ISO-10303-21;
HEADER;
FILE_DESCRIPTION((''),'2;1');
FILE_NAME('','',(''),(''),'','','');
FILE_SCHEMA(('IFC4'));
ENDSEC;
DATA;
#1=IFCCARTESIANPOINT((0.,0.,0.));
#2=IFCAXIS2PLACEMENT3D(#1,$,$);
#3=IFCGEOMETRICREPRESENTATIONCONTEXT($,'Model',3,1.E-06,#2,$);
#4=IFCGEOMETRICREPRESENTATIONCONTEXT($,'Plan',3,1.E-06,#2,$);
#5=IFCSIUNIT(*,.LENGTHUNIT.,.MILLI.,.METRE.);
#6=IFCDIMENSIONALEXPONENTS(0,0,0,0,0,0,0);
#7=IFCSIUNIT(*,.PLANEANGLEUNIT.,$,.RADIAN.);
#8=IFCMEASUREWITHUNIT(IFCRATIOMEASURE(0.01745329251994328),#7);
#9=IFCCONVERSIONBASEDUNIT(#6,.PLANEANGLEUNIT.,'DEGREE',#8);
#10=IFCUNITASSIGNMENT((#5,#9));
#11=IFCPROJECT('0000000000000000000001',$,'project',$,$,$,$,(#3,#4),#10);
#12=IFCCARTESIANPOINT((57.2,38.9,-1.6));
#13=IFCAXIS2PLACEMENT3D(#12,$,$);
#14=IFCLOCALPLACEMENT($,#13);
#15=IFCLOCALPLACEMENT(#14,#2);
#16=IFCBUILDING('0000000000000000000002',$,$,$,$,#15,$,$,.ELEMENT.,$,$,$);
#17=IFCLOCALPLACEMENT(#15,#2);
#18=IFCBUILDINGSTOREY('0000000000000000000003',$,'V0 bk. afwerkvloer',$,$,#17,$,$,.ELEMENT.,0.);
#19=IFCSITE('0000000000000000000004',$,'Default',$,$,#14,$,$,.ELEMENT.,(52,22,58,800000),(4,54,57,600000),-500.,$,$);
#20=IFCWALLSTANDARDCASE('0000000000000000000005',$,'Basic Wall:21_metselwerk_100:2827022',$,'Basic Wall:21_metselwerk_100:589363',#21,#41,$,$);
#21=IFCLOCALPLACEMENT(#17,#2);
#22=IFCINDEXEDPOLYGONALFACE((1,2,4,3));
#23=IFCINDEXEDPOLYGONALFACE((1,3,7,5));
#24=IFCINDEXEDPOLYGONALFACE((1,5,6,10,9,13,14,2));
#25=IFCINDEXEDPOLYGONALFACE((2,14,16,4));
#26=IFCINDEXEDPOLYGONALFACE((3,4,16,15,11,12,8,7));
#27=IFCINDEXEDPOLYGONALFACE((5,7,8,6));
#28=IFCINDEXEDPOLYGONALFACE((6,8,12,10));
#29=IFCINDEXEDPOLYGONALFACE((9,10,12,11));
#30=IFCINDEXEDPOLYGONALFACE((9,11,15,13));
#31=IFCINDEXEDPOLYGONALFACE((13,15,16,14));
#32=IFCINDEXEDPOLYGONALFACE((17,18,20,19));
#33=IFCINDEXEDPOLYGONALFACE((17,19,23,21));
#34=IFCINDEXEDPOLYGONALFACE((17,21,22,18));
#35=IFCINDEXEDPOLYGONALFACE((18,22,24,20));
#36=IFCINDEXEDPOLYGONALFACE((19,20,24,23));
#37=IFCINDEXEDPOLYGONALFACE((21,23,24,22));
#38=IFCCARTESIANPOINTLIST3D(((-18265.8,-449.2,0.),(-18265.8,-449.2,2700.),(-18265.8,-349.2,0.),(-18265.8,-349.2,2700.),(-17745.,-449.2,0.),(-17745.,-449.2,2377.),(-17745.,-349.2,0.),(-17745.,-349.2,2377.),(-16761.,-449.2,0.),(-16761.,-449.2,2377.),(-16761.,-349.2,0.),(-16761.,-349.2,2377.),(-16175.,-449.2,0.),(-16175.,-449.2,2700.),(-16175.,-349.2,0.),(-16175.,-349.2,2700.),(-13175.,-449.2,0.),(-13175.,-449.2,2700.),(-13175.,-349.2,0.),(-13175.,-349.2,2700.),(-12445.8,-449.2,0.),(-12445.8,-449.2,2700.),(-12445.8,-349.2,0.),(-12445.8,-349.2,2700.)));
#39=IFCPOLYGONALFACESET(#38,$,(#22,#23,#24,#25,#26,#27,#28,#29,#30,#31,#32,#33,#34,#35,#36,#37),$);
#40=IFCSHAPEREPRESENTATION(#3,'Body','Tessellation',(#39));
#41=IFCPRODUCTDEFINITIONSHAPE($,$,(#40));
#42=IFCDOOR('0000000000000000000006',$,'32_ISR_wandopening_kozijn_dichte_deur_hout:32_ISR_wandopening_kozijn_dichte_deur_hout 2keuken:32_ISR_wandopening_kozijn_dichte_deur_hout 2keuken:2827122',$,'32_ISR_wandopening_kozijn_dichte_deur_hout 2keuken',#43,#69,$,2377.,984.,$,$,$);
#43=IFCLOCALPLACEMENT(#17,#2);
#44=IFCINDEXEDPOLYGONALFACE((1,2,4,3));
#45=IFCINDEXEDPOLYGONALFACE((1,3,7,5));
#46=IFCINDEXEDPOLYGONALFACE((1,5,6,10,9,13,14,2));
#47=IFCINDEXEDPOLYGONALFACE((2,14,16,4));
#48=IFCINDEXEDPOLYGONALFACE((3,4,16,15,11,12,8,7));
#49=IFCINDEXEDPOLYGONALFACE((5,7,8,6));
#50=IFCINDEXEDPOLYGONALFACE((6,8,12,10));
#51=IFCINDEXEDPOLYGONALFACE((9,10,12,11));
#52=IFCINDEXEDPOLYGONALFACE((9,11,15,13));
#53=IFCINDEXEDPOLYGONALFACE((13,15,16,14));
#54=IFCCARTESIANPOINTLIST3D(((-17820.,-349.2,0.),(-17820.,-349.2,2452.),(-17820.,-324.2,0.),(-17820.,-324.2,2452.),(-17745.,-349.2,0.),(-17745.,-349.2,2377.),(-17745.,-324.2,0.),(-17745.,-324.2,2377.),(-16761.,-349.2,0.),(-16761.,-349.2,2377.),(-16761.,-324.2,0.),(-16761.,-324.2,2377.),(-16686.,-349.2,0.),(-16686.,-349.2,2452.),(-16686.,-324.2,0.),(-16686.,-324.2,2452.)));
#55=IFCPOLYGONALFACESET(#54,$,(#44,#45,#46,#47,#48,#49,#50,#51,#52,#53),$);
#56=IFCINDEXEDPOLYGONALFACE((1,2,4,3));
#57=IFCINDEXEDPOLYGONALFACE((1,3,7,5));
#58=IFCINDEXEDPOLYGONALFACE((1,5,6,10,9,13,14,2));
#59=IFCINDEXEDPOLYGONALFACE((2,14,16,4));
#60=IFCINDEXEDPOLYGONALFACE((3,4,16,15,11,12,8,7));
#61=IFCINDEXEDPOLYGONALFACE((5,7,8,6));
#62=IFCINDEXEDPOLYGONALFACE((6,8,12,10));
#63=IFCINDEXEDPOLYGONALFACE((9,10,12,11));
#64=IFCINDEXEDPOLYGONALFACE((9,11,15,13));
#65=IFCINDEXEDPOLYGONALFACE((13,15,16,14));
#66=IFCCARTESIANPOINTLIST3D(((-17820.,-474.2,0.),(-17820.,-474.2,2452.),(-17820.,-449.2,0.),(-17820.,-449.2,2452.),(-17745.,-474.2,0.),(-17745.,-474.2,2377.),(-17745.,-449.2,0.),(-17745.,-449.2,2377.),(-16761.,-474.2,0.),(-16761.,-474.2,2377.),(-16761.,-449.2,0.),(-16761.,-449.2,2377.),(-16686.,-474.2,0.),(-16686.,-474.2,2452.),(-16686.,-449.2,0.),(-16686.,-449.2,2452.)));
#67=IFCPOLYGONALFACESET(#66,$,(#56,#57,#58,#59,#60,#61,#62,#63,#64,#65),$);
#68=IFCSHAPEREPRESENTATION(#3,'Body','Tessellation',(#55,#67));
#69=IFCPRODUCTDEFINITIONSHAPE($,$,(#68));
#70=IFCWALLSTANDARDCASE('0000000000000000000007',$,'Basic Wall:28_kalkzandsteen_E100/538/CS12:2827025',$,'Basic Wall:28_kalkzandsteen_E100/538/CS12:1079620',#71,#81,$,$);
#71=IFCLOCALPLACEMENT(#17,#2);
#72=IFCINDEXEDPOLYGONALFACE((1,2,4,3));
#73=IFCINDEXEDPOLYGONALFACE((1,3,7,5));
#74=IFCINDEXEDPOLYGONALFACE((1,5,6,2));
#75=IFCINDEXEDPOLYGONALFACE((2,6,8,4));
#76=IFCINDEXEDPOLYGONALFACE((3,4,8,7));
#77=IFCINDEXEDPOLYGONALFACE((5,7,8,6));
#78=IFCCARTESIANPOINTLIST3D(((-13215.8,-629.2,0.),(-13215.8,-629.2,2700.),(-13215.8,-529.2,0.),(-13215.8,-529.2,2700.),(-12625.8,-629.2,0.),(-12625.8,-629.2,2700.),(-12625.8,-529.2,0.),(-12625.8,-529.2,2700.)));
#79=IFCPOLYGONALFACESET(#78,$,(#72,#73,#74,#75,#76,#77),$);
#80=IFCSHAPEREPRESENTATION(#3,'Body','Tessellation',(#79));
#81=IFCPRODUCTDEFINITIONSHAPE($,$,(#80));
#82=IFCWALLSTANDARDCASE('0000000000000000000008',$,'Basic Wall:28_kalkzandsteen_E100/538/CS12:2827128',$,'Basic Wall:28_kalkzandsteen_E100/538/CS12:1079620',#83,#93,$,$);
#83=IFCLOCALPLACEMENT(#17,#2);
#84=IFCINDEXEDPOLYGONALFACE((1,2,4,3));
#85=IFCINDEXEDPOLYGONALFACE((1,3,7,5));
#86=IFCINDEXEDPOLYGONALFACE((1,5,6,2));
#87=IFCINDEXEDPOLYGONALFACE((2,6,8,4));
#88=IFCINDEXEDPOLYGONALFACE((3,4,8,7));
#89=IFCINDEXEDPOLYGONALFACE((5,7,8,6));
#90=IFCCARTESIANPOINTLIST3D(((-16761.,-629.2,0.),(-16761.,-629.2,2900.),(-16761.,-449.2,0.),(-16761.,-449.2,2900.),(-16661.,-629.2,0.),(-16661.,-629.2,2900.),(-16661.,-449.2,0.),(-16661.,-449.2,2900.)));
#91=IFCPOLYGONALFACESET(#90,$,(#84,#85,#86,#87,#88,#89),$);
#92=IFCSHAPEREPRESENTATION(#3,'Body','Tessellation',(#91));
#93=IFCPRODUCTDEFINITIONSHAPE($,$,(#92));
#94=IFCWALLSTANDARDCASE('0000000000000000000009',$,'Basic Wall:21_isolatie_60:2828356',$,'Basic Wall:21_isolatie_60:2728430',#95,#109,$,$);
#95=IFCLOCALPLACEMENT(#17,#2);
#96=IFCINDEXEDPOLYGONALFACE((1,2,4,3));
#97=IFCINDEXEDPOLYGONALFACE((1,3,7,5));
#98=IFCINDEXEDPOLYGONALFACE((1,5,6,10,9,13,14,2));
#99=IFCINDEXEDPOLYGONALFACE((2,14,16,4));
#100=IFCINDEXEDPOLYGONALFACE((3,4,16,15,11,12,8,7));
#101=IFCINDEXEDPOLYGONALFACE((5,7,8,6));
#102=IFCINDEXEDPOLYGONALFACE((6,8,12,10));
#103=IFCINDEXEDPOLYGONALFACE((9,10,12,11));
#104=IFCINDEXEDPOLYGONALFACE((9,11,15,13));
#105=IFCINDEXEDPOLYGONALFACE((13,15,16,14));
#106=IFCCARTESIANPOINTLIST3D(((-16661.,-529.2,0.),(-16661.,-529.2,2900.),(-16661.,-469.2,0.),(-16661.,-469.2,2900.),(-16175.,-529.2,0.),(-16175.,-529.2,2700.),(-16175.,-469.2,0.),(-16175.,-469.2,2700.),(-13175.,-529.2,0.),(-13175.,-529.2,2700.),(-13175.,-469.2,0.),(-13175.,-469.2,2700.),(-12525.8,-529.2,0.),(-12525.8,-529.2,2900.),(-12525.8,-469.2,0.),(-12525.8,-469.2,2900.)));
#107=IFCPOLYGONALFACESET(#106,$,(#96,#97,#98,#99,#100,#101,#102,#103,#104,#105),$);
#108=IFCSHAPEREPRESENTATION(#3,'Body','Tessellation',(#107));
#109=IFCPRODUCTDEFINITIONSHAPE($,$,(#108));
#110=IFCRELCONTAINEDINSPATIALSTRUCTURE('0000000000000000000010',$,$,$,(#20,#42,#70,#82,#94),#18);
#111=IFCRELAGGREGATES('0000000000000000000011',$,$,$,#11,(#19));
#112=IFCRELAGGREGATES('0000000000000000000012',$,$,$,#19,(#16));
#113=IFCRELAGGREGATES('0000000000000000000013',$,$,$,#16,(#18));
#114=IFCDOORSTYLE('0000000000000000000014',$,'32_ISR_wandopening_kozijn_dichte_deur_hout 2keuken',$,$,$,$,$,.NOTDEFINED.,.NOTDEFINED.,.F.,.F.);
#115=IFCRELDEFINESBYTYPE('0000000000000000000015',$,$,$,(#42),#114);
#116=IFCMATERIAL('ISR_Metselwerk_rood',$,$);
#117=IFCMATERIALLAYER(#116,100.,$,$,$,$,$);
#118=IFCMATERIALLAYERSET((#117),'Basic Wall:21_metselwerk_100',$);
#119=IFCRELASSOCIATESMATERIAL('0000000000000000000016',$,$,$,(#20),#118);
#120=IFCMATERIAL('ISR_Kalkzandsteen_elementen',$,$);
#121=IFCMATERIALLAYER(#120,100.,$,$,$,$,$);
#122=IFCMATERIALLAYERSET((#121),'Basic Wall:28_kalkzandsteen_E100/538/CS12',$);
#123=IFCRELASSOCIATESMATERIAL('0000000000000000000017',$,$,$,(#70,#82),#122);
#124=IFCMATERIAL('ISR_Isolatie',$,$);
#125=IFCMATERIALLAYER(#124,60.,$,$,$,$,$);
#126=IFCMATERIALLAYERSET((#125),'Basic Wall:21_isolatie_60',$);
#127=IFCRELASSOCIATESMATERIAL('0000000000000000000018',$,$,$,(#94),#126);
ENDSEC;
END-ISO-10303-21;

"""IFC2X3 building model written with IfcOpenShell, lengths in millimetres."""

from ifc_helpers import new_model, entity, si_unit, converted_unit, frame, frame_2d, origin, origin_2d_with_axis, place, context, project, spatial, polyline, rectangle, outline, extrude, source, transform, mapped, material, layer, layer_set, layer_usage, type_object, type_shapes, element, fill, save


model = new_model("IFC2X3")

# Units and contexts
model_context = context("Model", 3, precision=1e-06, world=origin())
plan_context = context("Plan", 3, precision=1e-06, world=origin())
ifc_project = project(units=[si_unit("LENGTHUNIT", "METRE", prefix="MILLI"), converted_unit("PLANEANGLEUNIT", "DEGREE", entity("IfcRatioMeasure", 0.01745329251994328), si_unit("PLANEANGLEUNIT", "RADIAN"), dimensions=[0, 0, 0, 0, 0, 0, 0])], contexts=[model_context, plan_context])

# Site, building, storey
site_placement = place(None, frame((57.2, 38.9, -1.6)))
site = spatial("IfcSite", under=ifc_project, at=site_placement, Name="Default", CompositionType="ELEMENT", RefLatitude=(52, 22, 58, 800000), RefLongitude=(4, 54, 57, 600000), RefElevation=-500.0)
building_placement = place(site_placement, origin())
building = spatial("IfcBuilding", under=site, at=building_placement, CompositionType="ELEMENT")
storey_placement = place(building_placement, origin())
storey = spatial("IfcBuildingStorey", under=building, at=storey_placement, Name="V0 bk. afwerkvloer", CompositionType="ELEMENT", Elevation=0.0)

# Shared definitions
ifc_material_1 = material(Name="ISR_Kalkzandsteen_elementen")
ifc_layer_1 = layer(ifc_material_1, 100.0)
ifc_layer_set_1 = layer_set([ifc_layer_1], Name="Basic Wall:28_kalkzandsteen_E100/538/CS12")

# Wall, openings, door
ifc_material_2 = material(Name="ISR_Metselwerk_rood")
ifc_layer_2 = layer(ifc_material_2, 100.0)
ifc_layer_set_2 = layer_set([ifc_layer_2], Name="Basic Wall:21_metselwerk_100")
ifc_layer_usage_1 = layer_usage(ifc_layer_set_2, "AXIS2", "NEGATIVE", 50.0)
wall_1_placement = place(storey_placement, frame((-18265.8, -399.2, 0.0)))
wall_1 = element("IfcWallStandardCase", 1, at=wall_1_placement, inside=storey, material=ifc_layer_usage_1, Name="Basic Wall:21_metselwerk_100:2827022", ObjectType="Basic Wall:21_metselwerk_100:589363", context=model_context, shape_type="SweptSolid", body=[
    extrude(rectangle(XDim=5820.0, YDim=100.0, at=frame_2d((2910.0, 0.0), x_axis=(-1.0, 0.0))), origin(), (0.0, 0.0, 1.0), 2700.0),
])
opening_1_placement = place(wall_1_placement, origin())
element("IfcOpeningElement", 2, at=opening_1_placement, cuts=wall_1, ObjectType="Opening", context=model_context, shape_type="SweptSolid", body=[
    extrude(rectangle(XDim=2700.0, YDim=3000.0, at=origin_2d_with_axis()), frame((3590.8, -202.4, 1350.0), z_axis=(0.0, 1.0, 0.0), x_axis=(0.0, 0.0, 1.0)), (0.0, 0.0, 1.0), 404.8),
])
opening_2_placement = place(wall_1_placement, frame((520.8, -50.0, 0.0)))
opening_2 = element("IfcOpeningElement", 3, at=opening_2_placement, cuts=wall_1, ObjectType="Opening", context=model_context, shape_type="SweptSolid", body=[
    extrude(rectangle(XDim=2377.0, YDim=984.0, at=frame_2d((1188.5, 492.0), x_axis=(1.0, 0.0))), frame((0.0, 0.0, 0.0), z_axis=(0.0, 1.0, 0.0), x_axis=(0.0, 0.0, 1.0)), (0.0, 0.0, 1.0), 100.0),
])
door_style_1 = type_object("IfcDoorStyle", Name="32_ISR_wandopening_kozijn_dichte_deur_hout 2keuken", ConstructionType="NOTDEFINED", OperationType="NOTDEFINED", ParameterTakesPrecedence=False, Sizeable=False)
shared_shape_1 = source(origin(), model_context, "Body", "SweptSolid", [
    extrude(outline(polyline([(-1169.7, 492.0), (1207.2, 492.0), (1207.2, 567.0), (-1244.7, 567.0), (-1244.7, -567.0), (1207.2, -567.0), (1207.2, -492.0), (-1169.7, -492.0), (-1169.7, 492.0)])), frame((1202.0, 125.0, 1207.2), z_axis=(0.0, -1.0, 0.0), x_axis=(0.0, 0.0, -1.0)), (0.0, 0.0, 1.0), 25.0),
    extrude(outline(polyline([(-567.0, -1244.7), (567.0, -1244.7), (567.0, 1207.2), (492.0, 1207.2), (492.0, -1169.7), (-492.0, -1169.7), (-492.0, 1207.2), (-567.0, 1207.2), (-567.0, -1244.7)])), frame((1202.0, 0.0, 1207.2), z_axis=(0.0, -1.0, 0.0), x_axis=(-1.0, 0.0, 0.0)), (0.0, 0.0, 1.0), 25.0),
])
type_shapes(door_style_1, [shared_shape_1])
door_1_placement = place(opening_2_placement, frame((-710.0, 0.0, 0.0)))
door_1 = element("IfcDoor", 4, at=door_1_placement, inside=storey, type_object=door_style_1, Name="32_ISR_wandopening_kozijn_dichte_deur_hout:32_ISR_wandopening_kozijn_dichte_deur_hout 2keuken:32_ISR_wandopening_kozijn_dichte_deur_hout 2keuken:2827122", ObjectType="32_ISR_wandopening_kozijn_dichte_deur_hout 2keuken", OverallHeight=2377.0, OverallWidth=984.0, context=model_context, shape_type="MappedRepresentation", body=[
    mapped(shared_shape_1, transform((0.0, 0.0, 0.0), scale=1.0)),
])
fill(opening_2, door_1)

# Wall
ifc_layer_usage_2 = layer_usage(ifc_layer_set_1, "AXIS2", "POSITIVE", -50.0)
wall_2_placement = place(storey_placement, frame((-13215.8, -579.2, 0.0)))
element("IfcWallStandardCase", 5, at=wall_2_placement, inside=storey, material=ifc_layer_usage_2, Name="Basic Wall:28_kalkzandsteen_E100/538/CS12:2827025", ObjectType="Basic Wall:28_kalkzandsteen_E100/538/CS12:1079620", context=model_context, shape_type="SweptSolid", body=[
    extrude(rectangle(XDim=590.0, YDim=100.0, at=frame_2d((295.0, 0.0), x_axis=(-1.0, 0.0))), origin(), (0.0, 0.0, 1.0), 2700.0),
])

# Wall
ifc_layer_usage_3 = layer_usage(ifc_layer_set_1, "AXIS2", "NEGATIVE", 50.0)
wall_3_placement = place(storey_placement, frame((-16711.0, -629.2, 0.0), z_axis=(0.0, 0.0, 1.0), x_axis=(0.0, 1.0, 0.0)))
element("IfcWallStandardCase", 6, at=wall_3_placement, inside=storey, material=ifc_layer_usage_3, Name="Basic Wall:28_kalkzandsteen_E100/538/CS12:2827128", ObjectType="Basic Wall:28_kalkzandsteen_E100/538/CS12:1079620", context=model_context, shape_type="SweptSolid", body=[
    extrude(rectangle(XDim=180.0, YDim=100.0, at=frame_2d((90.0, 0.0), x_axis=(-1.0, 0.0))), origin(), (0.0, 0.0, 1.0), 2900.0),
])

# Wall, opening
ifc_material_3 = material(Name="ISR_Isolatie")
ifc_layer_3 = layer(ifc_material_3, 60.0)
ifc_layer_set_3 = layer_set([ifc_layer_3], Name="Basic Wall:21_isolatie_60")
ifc_layer_usage_4 = layer_usage(ifc_layer_set_3, "AXIS2", "POSITIVE", -30.0)
wall_4_placement = place(storey_placement, frame((-16661.0, -499.2, 0.0)))
wall_4 = element("IfcWallStandardCase", 7, at=wall_4_placement, inside=storey, material=ifc_layer_usage_4, Name="Basic Wall:21_isolatie_60:2828356", ObjectType="Basic Wall:21_isolatie_60:2728430", context=model_context, shape_type="SweptSolid", body=[
    extrude(rectangle(XDim=4135.2, YDim=60.0, at=frame_2d((2067.6, 0.0), x_axis=(-1.0, 0.0))), origin(), (0.0, 0.0, 1.0), 2900.0),
])
opening_3_placement = place(wall_4_placement, origin())
element("IfcOpeningElement", 8, at=opening_3_placement, cuts=wall_4, ObjectType="Opening", context=model_context, shape_type="SweptSolid", body=[
    extrude(rectangle(XDim=2700.0, YDim=3000.0, at=origin_2d_with_axis()), frame((1986.0, -182.4, 1350.0), z_axis=(0.0, 1.0, 0.0), x_axis=(0.0, 0.0, 1.0)), (0.0, 0.0, 1.0), 364.8),
])

save(model, "model.ifc")
